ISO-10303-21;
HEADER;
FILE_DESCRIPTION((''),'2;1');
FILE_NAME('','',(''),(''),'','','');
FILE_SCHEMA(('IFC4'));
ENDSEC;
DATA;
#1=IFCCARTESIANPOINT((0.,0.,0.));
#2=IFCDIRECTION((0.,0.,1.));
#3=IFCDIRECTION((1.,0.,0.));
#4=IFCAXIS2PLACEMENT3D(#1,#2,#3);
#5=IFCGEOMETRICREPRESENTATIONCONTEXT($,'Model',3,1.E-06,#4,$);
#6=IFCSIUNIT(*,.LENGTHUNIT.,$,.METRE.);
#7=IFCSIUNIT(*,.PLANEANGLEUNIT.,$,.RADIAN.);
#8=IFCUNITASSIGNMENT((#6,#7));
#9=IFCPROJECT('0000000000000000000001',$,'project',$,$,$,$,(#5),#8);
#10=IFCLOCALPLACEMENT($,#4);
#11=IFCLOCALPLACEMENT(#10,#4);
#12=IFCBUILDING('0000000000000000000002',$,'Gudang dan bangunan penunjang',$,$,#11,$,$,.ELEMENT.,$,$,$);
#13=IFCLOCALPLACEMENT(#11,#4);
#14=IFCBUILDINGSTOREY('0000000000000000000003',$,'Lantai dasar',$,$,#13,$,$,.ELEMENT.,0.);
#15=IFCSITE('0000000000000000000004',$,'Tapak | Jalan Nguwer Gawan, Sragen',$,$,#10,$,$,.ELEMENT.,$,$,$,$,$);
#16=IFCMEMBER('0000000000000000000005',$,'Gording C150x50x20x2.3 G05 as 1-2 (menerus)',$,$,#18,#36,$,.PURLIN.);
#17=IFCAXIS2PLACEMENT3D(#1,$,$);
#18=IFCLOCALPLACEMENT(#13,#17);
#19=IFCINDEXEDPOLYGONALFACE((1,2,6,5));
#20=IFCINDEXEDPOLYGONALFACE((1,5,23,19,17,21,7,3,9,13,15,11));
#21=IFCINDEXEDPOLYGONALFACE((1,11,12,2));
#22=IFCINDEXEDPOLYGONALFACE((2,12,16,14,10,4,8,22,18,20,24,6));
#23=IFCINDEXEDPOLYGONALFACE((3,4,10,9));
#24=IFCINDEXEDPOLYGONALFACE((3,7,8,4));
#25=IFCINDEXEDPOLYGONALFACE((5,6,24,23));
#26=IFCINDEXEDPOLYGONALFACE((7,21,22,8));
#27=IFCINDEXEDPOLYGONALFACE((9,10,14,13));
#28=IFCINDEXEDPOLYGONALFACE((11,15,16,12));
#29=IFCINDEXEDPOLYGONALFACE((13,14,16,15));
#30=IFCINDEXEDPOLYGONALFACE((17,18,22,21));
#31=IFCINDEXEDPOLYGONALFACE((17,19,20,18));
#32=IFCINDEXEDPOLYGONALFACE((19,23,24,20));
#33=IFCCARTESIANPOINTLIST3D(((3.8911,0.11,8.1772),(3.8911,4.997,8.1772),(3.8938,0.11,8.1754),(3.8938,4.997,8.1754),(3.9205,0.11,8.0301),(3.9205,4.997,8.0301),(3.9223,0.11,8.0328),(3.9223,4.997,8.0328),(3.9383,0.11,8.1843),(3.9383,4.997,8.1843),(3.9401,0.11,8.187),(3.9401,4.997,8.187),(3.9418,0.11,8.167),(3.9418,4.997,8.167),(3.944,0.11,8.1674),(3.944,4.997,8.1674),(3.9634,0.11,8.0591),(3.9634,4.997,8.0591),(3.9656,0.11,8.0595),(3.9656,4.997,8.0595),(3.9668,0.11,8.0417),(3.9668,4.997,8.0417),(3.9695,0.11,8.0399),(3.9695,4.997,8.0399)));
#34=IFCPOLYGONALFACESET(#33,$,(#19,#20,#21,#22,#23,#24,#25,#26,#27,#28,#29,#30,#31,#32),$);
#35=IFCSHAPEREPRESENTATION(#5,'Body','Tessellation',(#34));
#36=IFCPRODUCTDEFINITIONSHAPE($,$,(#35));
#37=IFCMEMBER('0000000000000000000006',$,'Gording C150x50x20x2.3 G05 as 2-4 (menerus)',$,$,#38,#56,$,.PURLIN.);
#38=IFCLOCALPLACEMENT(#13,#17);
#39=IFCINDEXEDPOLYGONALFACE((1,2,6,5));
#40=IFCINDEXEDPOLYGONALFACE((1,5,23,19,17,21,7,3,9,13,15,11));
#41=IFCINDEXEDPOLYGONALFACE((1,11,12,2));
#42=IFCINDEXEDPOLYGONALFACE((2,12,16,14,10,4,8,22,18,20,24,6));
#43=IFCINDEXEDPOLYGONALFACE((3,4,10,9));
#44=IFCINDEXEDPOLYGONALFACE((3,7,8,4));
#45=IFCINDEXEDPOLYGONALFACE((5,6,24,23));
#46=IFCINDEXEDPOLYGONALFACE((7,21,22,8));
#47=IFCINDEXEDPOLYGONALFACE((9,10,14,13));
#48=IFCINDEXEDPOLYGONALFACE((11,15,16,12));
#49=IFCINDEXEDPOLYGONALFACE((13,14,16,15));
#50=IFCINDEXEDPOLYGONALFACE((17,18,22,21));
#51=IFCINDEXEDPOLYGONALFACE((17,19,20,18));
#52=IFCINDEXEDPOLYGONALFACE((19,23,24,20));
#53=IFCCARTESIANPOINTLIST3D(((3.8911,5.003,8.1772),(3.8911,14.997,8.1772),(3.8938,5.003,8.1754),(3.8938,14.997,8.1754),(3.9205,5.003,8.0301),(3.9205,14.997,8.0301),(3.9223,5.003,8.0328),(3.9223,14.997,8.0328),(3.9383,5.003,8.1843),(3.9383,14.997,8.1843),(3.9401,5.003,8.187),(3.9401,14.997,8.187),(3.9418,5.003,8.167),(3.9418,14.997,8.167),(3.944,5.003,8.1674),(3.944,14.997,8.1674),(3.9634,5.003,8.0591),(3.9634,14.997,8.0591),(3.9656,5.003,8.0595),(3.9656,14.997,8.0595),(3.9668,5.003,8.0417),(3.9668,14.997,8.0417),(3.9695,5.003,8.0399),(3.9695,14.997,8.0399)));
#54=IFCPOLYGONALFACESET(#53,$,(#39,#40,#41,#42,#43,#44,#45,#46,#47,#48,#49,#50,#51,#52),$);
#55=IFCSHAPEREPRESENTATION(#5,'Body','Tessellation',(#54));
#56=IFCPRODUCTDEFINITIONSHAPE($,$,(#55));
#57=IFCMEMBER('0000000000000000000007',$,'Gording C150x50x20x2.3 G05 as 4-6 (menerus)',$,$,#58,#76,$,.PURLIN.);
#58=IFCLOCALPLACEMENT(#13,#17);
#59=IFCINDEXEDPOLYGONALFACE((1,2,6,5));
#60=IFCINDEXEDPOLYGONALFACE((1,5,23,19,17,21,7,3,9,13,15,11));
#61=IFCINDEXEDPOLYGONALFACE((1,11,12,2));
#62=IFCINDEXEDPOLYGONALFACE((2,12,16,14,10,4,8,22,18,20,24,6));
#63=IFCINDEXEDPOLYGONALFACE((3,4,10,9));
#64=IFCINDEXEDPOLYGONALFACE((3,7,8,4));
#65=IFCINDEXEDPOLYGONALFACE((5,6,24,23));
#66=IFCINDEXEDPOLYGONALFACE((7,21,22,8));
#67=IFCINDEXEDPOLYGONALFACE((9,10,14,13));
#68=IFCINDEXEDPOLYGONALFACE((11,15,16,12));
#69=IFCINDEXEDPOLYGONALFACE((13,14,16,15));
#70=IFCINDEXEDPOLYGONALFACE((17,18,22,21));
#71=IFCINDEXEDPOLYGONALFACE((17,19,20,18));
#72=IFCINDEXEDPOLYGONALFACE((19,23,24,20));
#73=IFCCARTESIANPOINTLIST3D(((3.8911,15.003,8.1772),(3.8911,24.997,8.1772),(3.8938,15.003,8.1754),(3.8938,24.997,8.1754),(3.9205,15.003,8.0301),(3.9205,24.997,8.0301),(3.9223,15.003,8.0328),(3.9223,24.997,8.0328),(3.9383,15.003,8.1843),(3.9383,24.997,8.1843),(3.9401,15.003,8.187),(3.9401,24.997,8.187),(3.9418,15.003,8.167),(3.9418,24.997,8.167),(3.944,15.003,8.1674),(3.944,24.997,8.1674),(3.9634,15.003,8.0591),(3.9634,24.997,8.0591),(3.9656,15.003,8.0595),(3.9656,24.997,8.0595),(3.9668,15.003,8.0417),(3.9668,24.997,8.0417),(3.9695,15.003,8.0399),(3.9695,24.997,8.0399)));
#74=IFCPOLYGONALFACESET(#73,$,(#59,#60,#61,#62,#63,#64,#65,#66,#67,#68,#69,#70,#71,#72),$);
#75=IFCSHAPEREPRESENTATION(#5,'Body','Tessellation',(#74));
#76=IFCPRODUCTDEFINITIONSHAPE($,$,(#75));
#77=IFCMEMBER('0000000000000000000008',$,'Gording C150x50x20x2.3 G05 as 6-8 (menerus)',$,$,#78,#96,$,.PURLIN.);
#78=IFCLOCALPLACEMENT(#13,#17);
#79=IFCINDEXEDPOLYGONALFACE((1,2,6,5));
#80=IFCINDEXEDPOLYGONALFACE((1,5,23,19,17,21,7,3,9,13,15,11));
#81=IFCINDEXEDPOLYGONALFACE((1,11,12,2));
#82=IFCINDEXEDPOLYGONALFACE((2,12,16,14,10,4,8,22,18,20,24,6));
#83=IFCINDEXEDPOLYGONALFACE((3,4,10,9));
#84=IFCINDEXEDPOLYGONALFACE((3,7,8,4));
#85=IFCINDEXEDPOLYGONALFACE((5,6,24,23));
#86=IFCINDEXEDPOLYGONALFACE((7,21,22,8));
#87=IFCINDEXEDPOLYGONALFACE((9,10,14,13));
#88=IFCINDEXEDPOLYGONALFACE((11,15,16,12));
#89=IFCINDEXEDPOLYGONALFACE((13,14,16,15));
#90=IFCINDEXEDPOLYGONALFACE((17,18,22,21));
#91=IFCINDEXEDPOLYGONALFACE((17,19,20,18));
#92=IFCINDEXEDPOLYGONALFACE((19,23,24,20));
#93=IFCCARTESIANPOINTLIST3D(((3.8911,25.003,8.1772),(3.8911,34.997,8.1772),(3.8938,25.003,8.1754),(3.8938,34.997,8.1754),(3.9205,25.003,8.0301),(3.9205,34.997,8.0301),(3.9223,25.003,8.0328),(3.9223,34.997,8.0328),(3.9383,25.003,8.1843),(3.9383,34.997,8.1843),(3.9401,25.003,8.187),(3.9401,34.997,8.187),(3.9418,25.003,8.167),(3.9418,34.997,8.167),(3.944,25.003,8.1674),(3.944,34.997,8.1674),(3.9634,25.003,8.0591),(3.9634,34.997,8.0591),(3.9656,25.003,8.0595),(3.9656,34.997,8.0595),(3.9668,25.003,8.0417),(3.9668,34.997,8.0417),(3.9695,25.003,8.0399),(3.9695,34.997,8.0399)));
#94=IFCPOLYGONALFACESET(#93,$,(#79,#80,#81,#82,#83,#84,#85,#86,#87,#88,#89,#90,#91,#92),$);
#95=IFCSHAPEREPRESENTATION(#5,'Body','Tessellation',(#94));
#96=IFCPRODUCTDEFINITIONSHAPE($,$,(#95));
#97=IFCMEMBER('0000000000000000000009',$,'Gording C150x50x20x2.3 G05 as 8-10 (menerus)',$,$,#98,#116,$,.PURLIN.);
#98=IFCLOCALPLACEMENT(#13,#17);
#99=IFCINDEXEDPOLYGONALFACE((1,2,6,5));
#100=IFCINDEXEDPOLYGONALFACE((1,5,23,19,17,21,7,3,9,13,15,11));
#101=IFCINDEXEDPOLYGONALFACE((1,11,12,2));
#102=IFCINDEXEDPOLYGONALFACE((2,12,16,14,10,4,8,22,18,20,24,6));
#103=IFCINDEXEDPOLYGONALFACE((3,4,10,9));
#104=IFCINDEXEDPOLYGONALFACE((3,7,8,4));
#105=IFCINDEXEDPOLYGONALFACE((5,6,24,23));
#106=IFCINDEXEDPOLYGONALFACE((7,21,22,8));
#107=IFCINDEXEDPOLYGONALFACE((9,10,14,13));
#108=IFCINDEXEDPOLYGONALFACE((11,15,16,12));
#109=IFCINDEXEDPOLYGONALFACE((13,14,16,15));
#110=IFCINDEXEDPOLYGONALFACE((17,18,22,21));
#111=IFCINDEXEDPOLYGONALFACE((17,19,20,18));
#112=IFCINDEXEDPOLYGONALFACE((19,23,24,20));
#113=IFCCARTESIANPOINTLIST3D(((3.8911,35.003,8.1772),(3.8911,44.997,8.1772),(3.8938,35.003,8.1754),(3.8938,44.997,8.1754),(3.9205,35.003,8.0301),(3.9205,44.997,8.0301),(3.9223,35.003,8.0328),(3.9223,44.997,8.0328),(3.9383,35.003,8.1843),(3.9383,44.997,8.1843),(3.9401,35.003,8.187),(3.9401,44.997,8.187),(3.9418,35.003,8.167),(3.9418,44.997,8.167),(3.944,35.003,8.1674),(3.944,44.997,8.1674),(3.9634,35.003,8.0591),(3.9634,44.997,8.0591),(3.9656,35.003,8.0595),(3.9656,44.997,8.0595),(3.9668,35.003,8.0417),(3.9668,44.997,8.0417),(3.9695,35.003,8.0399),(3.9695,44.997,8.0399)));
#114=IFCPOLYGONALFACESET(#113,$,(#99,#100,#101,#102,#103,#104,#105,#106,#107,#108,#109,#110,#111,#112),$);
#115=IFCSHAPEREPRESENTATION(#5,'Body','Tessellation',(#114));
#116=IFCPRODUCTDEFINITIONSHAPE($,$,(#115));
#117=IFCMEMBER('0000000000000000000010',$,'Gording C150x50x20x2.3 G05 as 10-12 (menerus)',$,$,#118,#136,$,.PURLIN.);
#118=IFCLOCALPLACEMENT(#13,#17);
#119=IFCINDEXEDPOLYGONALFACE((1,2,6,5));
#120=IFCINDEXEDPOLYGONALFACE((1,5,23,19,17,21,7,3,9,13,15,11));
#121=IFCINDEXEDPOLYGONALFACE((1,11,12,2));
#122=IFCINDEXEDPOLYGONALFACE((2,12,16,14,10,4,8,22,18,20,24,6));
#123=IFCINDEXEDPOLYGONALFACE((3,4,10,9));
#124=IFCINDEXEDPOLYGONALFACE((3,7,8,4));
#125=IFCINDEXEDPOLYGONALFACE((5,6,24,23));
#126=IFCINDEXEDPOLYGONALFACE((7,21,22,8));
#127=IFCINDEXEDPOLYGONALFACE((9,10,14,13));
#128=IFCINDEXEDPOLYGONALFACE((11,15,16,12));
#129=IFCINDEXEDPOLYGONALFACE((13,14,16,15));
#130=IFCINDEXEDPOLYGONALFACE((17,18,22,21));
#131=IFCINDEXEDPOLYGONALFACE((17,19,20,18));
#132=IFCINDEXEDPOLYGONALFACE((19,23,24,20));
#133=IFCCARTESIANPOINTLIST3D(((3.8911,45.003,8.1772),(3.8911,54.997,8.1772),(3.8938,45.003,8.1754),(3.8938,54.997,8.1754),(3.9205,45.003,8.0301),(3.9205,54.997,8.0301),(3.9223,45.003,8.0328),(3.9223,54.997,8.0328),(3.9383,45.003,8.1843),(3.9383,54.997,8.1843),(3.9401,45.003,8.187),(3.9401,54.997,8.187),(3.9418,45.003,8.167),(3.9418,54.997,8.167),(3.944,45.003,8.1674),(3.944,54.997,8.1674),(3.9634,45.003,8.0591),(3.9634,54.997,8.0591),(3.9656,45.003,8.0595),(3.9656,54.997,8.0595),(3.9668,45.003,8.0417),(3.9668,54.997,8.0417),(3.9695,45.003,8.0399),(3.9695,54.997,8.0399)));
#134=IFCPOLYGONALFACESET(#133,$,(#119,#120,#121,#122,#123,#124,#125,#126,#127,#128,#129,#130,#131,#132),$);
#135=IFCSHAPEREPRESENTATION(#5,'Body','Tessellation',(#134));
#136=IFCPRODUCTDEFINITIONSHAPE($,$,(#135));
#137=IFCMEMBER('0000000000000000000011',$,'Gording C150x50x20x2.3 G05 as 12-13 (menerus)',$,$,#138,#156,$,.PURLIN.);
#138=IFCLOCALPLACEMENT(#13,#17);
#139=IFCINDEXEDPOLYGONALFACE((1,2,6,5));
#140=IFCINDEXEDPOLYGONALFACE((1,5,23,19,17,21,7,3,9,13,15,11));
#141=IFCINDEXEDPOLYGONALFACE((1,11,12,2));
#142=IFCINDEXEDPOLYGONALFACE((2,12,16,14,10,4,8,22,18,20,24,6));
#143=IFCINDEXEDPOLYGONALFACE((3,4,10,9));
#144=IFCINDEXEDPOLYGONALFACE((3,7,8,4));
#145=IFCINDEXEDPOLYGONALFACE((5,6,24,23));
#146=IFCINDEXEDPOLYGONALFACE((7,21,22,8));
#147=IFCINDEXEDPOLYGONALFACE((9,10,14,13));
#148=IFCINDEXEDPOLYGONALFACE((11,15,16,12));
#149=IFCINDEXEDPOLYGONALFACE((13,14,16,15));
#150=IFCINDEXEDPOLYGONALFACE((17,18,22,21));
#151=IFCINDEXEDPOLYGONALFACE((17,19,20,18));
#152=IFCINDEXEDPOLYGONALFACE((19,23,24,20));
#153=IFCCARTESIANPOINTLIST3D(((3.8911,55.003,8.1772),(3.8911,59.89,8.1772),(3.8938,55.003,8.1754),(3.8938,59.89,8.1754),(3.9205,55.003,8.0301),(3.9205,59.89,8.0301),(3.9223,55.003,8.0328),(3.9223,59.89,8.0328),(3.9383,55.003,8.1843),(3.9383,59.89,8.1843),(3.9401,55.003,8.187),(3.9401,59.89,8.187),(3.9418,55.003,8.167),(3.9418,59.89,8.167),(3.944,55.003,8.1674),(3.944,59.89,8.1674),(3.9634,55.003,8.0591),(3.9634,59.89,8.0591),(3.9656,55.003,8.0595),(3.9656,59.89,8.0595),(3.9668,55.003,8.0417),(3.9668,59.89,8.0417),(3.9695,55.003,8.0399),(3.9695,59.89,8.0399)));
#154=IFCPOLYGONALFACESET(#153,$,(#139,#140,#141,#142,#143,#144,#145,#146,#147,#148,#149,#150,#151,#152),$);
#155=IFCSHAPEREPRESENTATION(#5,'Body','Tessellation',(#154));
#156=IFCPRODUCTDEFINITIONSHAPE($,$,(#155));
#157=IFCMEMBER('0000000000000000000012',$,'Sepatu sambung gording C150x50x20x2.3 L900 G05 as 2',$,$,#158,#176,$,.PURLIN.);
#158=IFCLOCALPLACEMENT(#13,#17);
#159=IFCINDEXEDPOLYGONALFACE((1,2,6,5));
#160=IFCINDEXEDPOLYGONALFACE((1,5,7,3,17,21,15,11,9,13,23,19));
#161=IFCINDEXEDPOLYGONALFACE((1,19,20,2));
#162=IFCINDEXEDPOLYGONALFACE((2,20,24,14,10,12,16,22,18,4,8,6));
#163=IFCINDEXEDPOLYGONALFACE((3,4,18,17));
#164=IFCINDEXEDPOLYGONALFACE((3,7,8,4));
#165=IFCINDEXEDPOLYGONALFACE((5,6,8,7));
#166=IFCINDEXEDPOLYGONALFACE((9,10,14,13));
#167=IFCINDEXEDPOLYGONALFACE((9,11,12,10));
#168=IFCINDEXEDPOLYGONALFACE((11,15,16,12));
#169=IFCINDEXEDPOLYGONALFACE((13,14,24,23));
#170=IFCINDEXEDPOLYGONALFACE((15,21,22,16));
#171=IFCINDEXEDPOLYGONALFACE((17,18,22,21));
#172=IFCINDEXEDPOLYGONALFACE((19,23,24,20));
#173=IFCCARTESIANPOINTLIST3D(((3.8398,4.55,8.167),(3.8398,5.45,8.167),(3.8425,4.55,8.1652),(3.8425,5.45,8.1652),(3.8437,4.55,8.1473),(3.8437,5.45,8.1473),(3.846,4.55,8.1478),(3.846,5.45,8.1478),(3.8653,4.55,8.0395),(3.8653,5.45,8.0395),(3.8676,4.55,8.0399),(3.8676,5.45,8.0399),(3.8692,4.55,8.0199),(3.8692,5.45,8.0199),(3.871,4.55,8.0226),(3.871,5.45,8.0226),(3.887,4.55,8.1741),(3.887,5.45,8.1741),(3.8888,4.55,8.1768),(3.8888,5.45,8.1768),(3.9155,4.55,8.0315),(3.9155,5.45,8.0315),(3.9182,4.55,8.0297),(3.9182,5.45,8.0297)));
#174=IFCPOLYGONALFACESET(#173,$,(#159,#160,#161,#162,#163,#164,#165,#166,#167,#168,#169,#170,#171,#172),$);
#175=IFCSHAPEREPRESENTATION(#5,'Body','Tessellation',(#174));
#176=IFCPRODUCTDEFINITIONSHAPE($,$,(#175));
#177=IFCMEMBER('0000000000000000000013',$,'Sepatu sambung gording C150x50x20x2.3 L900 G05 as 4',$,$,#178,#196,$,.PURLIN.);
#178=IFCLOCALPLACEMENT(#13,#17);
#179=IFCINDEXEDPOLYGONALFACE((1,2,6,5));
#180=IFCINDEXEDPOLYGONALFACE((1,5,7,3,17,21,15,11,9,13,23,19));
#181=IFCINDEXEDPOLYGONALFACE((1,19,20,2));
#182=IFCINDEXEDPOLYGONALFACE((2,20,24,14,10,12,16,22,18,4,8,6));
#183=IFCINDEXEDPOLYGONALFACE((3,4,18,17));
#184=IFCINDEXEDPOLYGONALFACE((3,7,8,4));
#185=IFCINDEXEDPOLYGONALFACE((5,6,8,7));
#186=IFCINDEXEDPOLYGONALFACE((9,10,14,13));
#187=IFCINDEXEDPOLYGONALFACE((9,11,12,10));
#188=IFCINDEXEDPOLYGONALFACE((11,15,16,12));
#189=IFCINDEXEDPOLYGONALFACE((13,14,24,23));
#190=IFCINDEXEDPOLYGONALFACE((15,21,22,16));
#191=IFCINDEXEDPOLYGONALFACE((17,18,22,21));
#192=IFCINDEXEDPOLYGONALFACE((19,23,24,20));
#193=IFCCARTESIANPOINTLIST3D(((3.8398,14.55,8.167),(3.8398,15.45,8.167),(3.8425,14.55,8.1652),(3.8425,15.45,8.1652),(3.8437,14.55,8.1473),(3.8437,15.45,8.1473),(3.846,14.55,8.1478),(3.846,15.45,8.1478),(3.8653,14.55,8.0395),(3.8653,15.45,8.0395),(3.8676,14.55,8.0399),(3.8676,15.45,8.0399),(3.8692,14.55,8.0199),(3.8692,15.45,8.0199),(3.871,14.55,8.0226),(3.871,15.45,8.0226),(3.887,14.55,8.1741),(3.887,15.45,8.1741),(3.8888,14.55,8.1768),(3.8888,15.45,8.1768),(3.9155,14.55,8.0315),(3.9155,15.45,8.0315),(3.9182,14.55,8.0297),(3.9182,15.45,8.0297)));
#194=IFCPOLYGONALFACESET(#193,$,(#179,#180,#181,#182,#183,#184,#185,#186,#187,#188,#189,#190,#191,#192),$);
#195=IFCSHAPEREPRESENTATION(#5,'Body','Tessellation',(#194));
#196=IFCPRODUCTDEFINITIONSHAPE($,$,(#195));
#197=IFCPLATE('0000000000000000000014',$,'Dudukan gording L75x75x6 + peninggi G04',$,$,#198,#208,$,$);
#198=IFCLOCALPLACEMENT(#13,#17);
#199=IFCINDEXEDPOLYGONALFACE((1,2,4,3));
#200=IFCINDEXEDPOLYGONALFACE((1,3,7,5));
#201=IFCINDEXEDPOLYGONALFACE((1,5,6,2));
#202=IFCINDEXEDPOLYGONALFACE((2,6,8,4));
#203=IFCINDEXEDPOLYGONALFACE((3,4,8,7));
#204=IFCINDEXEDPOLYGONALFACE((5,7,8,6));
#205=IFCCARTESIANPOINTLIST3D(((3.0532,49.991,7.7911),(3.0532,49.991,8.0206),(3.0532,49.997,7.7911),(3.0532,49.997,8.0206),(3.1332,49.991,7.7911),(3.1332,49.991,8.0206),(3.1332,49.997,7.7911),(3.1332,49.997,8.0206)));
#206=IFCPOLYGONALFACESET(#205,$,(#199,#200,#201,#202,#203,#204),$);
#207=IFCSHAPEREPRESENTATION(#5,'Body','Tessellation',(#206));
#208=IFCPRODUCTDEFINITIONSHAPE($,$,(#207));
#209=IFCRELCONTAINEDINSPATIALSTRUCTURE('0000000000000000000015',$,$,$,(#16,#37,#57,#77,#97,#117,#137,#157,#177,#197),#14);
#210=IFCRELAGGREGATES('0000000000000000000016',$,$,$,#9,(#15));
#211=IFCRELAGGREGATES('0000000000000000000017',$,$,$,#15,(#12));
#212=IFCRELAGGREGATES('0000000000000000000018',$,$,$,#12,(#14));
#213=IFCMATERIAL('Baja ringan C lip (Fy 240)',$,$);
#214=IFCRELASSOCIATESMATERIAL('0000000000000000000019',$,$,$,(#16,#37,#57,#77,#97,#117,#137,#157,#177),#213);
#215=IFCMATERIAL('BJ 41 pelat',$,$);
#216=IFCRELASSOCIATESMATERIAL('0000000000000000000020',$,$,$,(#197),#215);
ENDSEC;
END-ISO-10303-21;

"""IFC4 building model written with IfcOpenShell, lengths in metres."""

from ifc_helpers import new_model, si_unit, frame, origin_with_axes, place, context, project, spatial, rectangle, c_section, extrude, material, element, save


model = new_model("IFC4")

# Units and contexts
model_context = context("Model", 3, precision=1e-06, world=origin_with_axes())
ifc_project = project(units=[si_unit("LENGTHUNIT", "METRE"), si_unit("PLANEANGLEUNIT", "RADIAN")], contexts=[model_context])

# Site, building, storey
site_placement = place(None, origin_with_axes())
site = spatial("IfcSite", under=ifc_project, at=site_placement, Name="Tapak | Jalan Nguwer Gawan, Sragen", CompositionType="ELEMENT")
building_placement = place(site_placement, origin_with_axes())
building = spatial("IfcBuilding", under=site, at=building_placement, Name="Gudang dan bangunan penunjang", CompositionType="ELEMENT")
storey_placement = place(building_placement, origin_with_axes())
storey = spatial("IfcBuildingStorey", under=building, at=storey_placement, Name="Lantai dasar", CompositionType="ELEMENT", Elevation=0.0)

# Members
ifc_material_1 = material(Name="Baja ringan C lip (Fy 240)")
placement = place(None, origin_with_axes())
element("IfcMember", 1, at=placement, inside=storey, material=ifc_material_1, Name="Gording C150x50x20x2.3 G05 as 1-2 (menerus)", PredefinedType="PURLIN", context=model_context, shape_type="SweptSolid", body=[
    extrude(c_section(Depth=0.15, Width=0.05, WallThickness=0.0023, Girth=0.02), frame((3.9303, 0.11, 8.1086), z_axis=(0.0, 1.0, 0.0), x_axis=(0.980581, 0.0, 0.196116)), (0.0, 0.0, 1.0), 4.887),
])
element("IfcMember", 2, at=placement, inside=storey, material=ifc_material_1, Name="Gording C150x50x20x2.3 G05 as 2-4 (menerus)", PredefinedType="PURLIN", context=model_context, shape_type="SweptSolid", body=[
    extrude(c_section(Depth=0.15, Width=0.05, WallThickness=0.0023, Girth=0.02), frame((3.9303, 5.003, 8.1086), z_axis=(0.0, 1.0, 0.0), x_axis=(0.980581, 0.0, 0.196116)), (0.0, 0.0, 1.0), 9.994),
])
element("IfcMember", 3, at=placement, inside=storey, material=ifc_material_1, Name="Gording C150x50x20x2.3 G05 as 4-6 (menerus)", PredefinedType="PURLIN", context=model_context, shape_type="SweptSolid", body=[
    extrude(c_section(Depth=0.15, Width=0.05, WallThickness=0.0023, Girth=0.02), frame((3.9303, 15.003, 8.1086), z_axis=(0.0, 1.0, 0.0), x_axis=(0.980581, 0.0, 0.196116)), (0.0, 0.0, 1.0), 9.994),
])
element("IfcMember", 4, at=placement, inside=storey, material=ifc_material_1, Name="Gording C150x50x20x2.3 G05 as 6-8 (menerus)", PredefinedType="PURLIN", context=model_context, shape_type="SweptSolid", body=[
    extrude(c_section(Depth=0.15, Width=0.05, WallThickness=0.0023, Girth=0.02), frame((3.9303, 25.003, 8.1086), z_axis=(0.0, 1.0, 0.0), x_axis=(0.980581, 0.0, 0.196116)), (0.0, 0.0, 1.0), 9.994),
])
element("IfcMember", 5, at=placement, inside=storey, material=ifc_material_1, Name="Gording C150x50x20x2.3 G05 as 8-10 (menerus)", PredefinedType="PURLIN", context=model_context, shape_type="SweptSolid", body=[
    extrude(c_section(Depth=0.15, Width=0.05, WallThickness=0.0023, Girth=0.02), frame((3.9303, 35.003, 8.1086), z_axis=(0.0, 1.0, 0.0), x_axis=(0.980581, 0.0, 0.196116)), (0.0, 0.0, 1.0), 9.994),
])
element("IfcMember", 6, at=placement, inside=storey, material=ifc_material_1, Name="Gording C150x50x20x2.3 G05 as 10-12 (menerus)", PredefinedType="PURLIN", context=model_context, shape_type="SweptSolid", body=[
    extrude(c_section(Depth=0.15, Width=0.05, WallThickness=0.0023, Girth=0.02), frame((3.9303, 45.003, 8.1086), z_axis=(0.0, 1.0, 0.0), x_axis=(0.980581, 0.0, 0.196116)), (0.0, 0.0, 1.0), 9.994),
])
element("IfcMember", 7, at=placement, inside=storey, material=ifc_material_1, Name="Gording C150x50x20x2.3 G05 as 12-13 (menerus)", PredefinedType="PURLIN", context=model_context, shape_type="SweptSolid", body=[
    extrude(c_section(Depth=0.15, Width=0.05, WallThickness=0.0023, Girth=0.02), frame((3.9303, 55.003, 8.1086), z_axis=(0.0, 1.0, 0.0), x_axis=(0.980581, 0.0, 0.196116)), (0.0, 0.0, 1.0), 4.887),
])
element("IfcMember", 8, at=placement, inside=storey, material=ifc_material_1, Name="Sepatu sambung gording C150x50x20x2.3 L900 G05 as 2", PredefinedType="PURLIN", context=model_context, shape_type="SweptSolid", body=[
    extrude(c_section(Depth=0.15, Width=0.05, WallThickness=0.0023, Girth=0.02), frame((3.879, 4.55, 8.0983), z_axis=(0.0, 1.0, 0.0), x_axis=(-0.980581, 0.0, -0.196116)), (0.0, 0.0, 1.0), 0.9),
])
element("IfcMember", 9, at=placement, inside=storey, material=ifc_material_1, Name="Sepatu sambung gording C150x50x20x2.3 L900 G05 as 4", PredefinedType="PURLIN", context=model_context, shape_type="SweptSolid", body=[
    extrude(c_section(Depth=0.15, Width=0.05, WallThickness=0.0023, Girth=0.02), frame((3.879, 14.55, 8.0983), z_axis=(0.0, 1.0, 0.0), x_axis=(-0.980581, 0.0, -0.196116)), (0.0, 0.0, 1.0), 0.9),
])

# Plate
ifc_material_2 = material(Name="BJ 41 pelat")
element("IfcPlate", 10, at=placement, inside=storey, material=ifc_material_2, Name="Dudukan gording L75x75x6 + peninggi G04", context=model_context, shape_type="SweptSolid", body=[
    extrude(rectangle(XDim=0.08, YDim=0.006), frame((3.0932, 49.994, 7.7911), z_axis=(0.0, 0.0, 1.0), x_axis=(1.0, 0.0, 0.0)), (0.0, 0.0, 1.0), 0.2294),
])

save(model, "model.ifc")
